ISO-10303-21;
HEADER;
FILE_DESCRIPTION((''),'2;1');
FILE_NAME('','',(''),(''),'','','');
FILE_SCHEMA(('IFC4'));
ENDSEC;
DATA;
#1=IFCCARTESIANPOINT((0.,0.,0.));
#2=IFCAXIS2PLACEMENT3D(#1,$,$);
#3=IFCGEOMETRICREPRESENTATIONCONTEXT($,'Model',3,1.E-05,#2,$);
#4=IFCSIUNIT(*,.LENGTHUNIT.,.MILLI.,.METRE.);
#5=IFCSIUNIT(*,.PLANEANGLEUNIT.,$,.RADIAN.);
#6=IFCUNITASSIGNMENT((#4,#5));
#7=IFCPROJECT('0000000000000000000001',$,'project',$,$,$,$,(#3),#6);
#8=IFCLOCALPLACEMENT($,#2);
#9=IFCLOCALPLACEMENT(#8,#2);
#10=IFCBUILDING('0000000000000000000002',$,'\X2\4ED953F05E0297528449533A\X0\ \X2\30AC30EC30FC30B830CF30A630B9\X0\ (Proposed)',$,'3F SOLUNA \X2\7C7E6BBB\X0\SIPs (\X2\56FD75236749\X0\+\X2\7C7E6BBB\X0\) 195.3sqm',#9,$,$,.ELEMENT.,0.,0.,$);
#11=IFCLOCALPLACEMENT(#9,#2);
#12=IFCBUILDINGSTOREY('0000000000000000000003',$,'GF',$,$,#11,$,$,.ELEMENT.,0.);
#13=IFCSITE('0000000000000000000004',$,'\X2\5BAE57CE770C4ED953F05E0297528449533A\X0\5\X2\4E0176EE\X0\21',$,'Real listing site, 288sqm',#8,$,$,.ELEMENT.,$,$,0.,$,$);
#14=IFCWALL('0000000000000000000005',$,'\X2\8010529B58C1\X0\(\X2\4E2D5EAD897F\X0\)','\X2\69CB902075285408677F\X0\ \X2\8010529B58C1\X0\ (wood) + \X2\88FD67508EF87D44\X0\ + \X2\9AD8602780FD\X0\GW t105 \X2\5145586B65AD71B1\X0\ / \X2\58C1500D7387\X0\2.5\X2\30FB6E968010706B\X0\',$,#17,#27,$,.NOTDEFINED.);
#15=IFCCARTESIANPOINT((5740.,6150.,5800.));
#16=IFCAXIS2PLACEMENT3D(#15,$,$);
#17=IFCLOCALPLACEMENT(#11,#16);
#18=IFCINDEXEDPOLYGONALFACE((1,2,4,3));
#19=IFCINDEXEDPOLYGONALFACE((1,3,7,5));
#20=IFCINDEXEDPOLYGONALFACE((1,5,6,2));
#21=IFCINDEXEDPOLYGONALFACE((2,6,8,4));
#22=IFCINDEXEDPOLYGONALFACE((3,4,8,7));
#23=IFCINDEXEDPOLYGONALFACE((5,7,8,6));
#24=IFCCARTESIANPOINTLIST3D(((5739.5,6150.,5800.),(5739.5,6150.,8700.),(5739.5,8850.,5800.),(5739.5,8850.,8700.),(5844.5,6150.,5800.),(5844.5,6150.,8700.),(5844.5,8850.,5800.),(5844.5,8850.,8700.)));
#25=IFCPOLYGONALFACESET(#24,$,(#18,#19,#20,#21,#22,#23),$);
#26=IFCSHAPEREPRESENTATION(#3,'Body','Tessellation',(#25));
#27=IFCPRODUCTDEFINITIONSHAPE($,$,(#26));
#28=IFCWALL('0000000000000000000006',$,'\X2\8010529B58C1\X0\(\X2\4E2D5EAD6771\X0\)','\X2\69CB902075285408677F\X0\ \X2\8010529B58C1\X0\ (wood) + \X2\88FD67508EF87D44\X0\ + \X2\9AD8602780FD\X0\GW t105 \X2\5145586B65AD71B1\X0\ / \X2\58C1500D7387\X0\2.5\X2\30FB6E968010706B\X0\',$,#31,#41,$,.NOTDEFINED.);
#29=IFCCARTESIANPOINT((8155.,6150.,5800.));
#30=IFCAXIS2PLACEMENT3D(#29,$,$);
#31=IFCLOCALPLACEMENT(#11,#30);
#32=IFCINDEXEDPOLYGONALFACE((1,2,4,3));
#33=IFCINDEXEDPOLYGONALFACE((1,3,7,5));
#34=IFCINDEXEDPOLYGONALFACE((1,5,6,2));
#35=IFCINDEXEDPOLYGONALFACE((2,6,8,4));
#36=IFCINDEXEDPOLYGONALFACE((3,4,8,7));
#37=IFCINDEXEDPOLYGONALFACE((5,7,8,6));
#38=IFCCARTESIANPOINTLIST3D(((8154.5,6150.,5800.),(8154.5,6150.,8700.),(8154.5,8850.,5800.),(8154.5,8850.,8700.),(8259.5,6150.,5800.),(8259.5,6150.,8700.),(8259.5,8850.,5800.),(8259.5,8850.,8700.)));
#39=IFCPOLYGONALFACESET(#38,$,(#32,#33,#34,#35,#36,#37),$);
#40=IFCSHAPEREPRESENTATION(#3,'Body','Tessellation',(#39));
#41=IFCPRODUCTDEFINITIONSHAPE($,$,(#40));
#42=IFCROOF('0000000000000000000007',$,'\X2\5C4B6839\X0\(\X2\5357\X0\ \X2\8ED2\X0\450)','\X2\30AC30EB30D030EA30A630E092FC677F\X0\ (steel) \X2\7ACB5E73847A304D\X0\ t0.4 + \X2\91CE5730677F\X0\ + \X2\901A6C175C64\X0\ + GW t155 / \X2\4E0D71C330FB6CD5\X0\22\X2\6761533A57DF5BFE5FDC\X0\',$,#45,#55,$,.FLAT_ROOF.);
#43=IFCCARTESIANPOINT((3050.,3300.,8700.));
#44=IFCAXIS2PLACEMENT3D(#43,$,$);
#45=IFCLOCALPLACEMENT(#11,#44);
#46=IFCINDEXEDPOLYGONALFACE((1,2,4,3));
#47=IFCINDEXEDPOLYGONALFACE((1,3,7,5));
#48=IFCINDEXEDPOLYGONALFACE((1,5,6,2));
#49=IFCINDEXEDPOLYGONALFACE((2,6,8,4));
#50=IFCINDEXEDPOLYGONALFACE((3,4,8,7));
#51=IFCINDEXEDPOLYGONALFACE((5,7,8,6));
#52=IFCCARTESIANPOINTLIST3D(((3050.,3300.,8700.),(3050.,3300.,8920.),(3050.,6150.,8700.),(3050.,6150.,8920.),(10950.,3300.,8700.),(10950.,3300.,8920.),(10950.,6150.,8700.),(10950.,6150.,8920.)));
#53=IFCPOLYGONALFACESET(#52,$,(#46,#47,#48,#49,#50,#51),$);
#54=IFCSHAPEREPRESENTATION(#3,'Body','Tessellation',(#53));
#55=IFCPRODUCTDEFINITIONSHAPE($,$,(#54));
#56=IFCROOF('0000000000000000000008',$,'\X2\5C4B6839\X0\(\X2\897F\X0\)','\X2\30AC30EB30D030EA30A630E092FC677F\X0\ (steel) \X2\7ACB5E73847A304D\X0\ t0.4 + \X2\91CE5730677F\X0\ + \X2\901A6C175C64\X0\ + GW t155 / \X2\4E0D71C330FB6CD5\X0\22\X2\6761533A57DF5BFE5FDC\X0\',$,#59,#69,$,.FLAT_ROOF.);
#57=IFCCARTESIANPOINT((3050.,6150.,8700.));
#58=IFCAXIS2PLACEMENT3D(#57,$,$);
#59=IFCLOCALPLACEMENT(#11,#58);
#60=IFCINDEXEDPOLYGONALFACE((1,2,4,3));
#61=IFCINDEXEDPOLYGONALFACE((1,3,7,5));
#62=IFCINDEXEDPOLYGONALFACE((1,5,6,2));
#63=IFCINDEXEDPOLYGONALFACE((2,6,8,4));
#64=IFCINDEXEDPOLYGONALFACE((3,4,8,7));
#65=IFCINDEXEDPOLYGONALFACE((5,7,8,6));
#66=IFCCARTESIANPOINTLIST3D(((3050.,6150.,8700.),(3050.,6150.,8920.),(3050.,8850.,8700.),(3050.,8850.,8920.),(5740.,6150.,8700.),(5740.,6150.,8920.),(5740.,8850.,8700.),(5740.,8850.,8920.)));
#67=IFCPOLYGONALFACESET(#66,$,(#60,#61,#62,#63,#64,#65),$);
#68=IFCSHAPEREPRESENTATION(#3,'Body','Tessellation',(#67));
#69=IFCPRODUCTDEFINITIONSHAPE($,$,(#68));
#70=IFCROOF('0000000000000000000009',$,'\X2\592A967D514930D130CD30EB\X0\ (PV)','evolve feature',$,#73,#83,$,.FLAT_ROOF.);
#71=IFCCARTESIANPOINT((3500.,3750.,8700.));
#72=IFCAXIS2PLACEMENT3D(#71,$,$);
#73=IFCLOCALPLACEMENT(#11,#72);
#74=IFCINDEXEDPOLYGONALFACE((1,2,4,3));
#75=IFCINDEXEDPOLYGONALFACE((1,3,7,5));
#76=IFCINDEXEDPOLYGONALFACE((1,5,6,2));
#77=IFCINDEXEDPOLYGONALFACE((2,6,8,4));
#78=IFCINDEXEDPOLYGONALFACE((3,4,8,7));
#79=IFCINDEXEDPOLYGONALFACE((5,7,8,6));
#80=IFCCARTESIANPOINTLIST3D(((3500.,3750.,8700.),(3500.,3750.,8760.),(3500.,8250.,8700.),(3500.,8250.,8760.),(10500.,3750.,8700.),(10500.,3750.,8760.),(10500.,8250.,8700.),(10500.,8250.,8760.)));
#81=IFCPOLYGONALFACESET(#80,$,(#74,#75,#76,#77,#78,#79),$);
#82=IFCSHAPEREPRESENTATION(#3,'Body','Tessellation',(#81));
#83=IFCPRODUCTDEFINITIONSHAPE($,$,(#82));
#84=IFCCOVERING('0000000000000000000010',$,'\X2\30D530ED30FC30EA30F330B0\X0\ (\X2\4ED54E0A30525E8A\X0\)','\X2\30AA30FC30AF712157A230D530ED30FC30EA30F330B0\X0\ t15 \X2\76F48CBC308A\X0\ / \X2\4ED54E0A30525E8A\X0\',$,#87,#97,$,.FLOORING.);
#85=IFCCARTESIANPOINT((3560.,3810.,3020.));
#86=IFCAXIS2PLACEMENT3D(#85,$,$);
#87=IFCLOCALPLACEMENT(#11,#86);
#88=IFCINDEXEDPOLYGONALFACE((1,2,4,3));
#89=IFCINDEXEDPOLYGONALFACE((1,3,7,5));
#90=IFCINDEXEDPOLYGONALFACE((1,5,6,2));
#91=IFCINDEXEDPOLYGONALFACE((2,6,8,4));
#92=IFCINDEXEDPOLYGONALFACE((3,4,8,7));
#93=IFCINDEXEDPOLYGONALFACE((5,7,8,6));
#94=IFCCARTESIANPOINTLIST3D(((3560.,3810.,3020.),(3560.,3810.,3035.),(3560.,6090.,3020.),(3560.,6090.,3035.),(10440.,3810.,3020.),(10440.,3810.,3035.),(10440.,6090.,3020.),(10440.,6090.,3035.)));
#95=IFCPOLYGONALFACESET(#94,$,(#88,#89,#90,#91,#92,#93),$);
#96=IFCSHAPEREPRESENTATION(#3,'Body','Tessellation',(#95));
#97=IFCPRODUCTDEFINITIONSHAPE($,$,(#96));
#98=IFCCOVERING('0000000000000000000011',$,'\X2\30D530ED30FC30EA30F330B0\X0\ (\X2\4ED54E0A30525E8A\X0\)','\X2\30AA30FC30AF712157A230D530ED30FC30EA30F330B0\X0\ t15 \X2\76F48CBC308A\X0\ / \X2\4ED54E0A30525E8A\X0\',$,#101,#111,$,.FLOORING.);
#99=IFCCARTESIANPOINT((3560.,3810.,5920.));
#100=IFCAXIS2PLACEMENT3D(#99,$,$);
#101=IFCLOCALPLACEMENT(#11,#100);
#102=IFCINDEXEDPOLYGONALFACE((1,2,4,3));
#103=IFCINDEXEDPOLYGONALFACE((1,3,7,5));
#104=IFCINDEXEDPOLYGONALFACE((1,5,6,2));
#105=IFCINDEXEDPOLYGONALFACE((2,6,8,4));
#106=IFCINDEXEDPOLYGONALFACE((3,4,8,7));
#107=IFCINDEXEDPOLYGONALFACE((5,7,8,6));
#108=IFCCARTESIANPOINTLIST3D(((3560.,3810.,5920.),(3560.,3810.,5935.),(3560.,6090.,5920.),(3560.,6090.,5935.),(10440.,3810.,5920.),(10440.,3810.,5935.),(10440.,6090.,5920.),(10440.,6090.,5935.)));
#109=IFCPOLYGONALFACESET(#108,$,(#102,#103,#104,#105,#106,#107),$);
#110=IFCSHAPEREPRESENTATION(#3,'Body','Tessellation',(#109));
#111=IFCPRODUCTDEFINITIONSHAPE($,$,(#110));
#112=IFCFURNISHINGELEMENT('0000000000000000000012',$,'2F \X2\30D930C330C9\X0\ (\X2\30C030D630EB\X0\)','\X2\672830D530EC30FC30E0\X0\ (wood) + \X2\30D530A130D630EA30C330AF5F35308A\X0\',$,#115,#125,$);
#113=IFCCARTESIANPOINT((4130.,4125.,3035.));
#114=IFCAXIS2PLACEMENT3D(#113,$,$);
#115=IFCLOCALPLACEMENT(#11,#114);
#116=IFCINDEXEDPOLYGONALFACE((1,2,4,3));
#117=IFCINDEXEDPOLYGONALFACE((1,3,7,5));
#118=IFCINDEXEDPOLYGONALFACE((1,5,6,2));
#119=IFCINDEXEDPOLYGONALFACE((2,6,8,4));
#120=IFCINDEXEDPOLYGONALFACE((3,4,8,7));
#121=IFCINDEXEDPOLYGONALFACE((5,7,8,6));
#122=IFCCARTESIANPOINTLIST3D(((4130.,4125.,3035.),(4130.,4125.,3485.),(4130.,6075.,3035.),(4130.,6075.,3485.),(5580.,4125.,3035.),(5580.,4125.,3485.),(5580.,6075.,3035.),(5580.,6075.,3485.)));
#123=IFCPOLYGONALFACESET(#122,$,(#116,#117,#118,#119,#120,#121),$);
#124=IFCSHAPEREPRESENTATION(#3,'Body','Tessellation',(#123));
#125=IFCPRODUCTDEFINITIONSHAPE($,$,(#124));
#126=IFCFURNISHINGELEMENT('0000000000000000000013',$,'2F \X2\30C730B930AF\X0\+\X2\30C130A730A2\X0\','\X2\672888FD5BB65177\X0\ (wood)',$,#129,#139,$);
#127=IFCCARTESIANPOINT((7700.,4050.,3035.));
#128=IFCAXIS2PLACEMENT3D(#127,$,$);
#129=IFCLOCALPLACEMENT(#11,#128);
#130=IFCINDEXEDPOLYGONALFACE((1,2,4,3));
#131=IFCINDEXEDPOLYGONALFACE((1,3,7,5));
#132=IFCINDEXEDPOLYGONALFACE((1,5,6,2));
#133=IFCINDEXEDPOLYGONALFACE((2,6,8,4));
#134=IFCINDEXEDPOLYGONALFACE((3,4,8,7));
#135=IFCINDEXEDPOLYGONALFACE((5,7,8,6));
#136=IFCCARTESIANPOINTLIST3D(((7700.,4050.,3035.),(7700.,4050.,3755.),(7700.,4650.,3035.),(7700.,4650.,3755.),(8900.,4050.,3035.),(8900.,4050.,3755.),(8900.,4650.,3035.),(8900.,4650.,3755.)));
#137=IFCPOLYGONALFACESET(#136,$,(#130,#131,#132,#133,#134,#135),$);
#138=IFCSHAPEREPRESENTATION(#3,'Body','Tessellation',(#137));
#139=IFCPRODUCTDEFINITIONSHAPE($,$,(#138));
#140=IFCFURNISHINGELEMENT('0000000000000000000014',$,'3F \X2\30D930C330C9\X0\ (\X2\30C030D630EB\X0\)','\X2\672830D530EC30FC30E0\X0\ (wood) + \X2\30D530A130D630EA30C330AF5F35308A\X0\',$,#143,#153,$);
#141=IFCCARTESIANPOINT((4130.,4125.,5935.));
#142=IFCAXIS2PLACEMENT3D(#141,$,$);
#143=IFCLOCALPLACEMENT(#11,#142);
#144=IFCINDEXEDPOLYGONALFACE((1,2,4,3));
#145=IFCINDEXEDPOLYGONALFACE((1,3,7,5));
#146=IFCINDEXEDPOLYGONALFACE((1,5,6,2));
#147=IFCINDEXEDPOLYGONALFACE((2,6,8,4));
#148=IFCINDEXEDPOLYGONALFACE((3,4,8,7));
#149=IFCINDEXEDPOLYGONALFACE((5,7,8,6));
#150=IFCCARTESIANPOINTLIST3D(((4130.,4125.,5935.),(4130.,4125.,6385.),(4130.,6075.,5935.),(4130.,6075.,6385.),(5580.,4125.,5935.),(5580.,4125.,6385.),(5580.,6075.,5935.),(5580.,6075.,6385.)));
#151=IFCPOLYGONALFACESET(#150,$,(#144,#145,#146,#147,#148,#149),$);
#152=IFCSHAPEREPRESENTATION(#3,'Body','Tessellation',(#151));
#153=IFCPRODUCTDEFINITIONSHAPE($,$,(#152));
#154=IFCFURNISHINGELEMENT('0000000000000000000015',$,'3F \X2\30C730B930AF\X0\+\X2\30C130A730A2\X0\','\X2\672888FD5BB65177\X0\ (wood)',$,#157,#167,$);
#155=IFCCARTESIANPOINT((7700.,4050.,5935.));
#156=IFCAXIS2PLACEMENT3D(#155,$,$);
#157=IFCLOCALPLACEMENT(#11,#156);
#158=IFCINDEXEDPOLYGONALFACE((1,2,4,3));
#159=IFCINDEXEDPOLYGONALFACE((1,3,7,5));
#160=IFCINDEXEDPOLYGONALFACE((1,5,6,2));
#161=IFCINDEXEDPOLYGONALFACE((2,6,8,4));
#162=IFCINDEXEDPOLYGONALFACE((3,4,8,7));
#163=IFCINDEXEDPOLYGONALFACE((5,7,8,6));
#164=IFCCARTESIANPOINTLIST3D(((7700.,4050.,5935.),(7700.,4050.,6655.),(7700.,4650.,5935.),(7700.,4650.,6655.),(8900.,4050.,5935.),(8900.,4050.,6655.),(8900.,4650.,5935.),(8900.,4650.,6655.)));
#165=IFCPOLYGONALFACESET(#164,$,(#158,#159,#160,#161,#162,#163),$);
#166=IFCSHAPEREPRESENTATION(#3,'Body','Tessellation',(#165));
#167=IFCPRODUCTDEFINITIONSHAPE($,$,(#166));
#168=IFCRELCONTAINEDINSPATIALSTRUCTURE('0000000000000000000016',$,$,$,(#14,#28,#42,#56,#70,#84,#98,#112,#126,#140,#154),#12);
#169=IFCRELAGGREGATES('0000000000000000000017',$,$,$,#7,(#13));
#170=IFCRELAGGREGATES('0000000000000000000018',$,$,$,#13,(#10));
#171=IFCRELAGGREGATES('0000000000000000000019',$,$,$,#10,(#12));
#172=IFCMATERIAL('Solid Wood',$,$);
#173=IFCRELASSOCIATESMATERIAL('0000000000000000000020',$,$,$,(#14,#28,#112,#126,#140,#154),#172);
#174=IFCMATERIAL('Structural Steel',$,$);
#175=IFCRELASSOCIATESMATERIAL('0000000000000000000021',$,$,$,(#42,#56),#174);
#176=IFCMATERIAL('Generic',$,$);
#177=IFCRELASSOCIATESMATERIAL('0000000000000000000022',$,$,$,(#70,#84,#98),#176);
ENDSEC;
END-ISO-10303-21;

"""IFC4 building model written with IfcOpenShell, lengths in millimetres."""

from ifc_helpers import new_model, si_unit, frame, frame_2d, origin, place, context, project, spatial, rectangle, extrude, material, element, save


model = new_model("IFC4")

# Units and contexts
model_context = context("Model", 3, precision=1e-05, world=origin())
ifc_project = project(units=[si_unit("LENGTHUNIT", "METRE", prefix="MILLI"), si_unit("PLANEANGLEUNIT", "RADIAN")], contexts=[model_context])

# Site, building, storey
site_placement = place(None, origin())
site = spatial("IfcSite", under=ifc_project, at=site_placement, Name="宮城県仙台市青葉区5丁目21", ObjectType="Real listing site, 288sqm", CompositionType="ELEMENT", RefElevation=0.0)
building_placement = place(site_placement, origin())
building = spatial("IfcBuilding", under=site, at=building_placement, Name="仙台市青葉区 ガレージハウス (Proposed)", ObjectType="3F SOLUNA 籾殻SIPs (国産杉+籾殻) 195.3sqm", CompositionType="ELEMENT", ElevationOfRefHeight=0.0, ElevationOfTerrain=0.0)
storey_placement = place(building_placement, origin())
storey = spatial("IfcBuildingStorey", under=building, at=storey_placement, Name="GF", CompositionType="ELEMENT", Elevation=0.0)

# Shared definitions
ifc_material_1 = material(Name="Solid Wood")

# Walls
wall_1_placement = place(storey_placement, frame((5740.0, 6150.0, 5800.0)))
element("IfcWall", 1, at=wall_1_placement, inside=storey, material=ifc_material_1, Name="耐力壁(中庭西)", Description="構造用合板 耐力壁 (wood) + 製材軸組 + 高性能GW t105 充填断熱 / 壁倍率2.5・準耐火", PredefinedType="NOTDEFINED", context=model_context, shape_type="SweptSolid", body=[
    extrude(rectangle(XDim=105.0, YDim=2700.0, at=frame_2d((52.0, 1350.0))), frame((5740.0, 6150.0, 5800.0)), (0.0, 0.0, 1.0), 2900.0),
])
wall_2_placement = place(storey_placement, frame((8155.0, 6150.0, 5800.0)))
element("IfcWall", 2, at=wall_2_placement, inside=storey, material=ifc_material_1, Name="耐力壁(中庭東)", Description="構造用合板 耐力壁 (wood) + 製材軸組 + 高性能GW t105 充填断熱 / 壁倍率2.5・準耐火", PredefinedType="NOTDEFINED", context=model_context, shape_type="SweptSolid", body=[
    extrude(rectangle(XDim=105.0, YDim=2700.0, at=frame_2d((52.0, 1350.0))), frame((8155.0, 6150.0, 5800.0)), (0.0, 0.0, 1.0), 2900.0),
])

# Roofs
ifc_material_2 = material(Name="Structural Steel")
roof_1_placement = place(storey_placement, frame((3050.0, 3300.0, 8700.0)))
element("IfcRoof", 3, at=roof_1_placement, inside=storey, material=ifc_material_2, Name="屋根(南 軒450)", Description="ガルバリウム鋼板 (steel) 立平葺き t0.4 + 野地板 + 通気層 + GW t155 / 不燃・法22条区域対応", PredefinedType="FLAT_ROOF", context=model_context, shape_type="SweptSolid", body=[
    extrude(rectangle(XDim=7900.0, YDim=2850.0, at=frame_2d((3950.0, 1425.0))), frame((3050.0, 3300.0, 8700.0)), (0.0, 0.0, 1.0), 220.0),
])
roof_2_placement = place(storey_placement, frame((3050.0, 6150.0, 8700.0)))
element("IfcRoof", 4, at=roof_2_placement, inside=storey, material=ifc_material_2, Name="屋根(西)", Description="ガルバリウム鋼板 (steel) 立平葺き t0.4 + 野地板 + 通気層 + GW t155 / 不燃・法22条区域対応", PredefinedType="FLAT_ROOF", context=model_context, shape_type="SweptSolid", body=[
    extrude(rectangle(XDim=2690.0, YDim=2700.0, at=frame_2d((1345.0, 1350.0))), frame((3050.0, 6150.0, 8700.0)), (0.0, 0.0, 1.0), 220.0),
])
ifc_material_3 = material(Name="Generic")
roof_3_placement = place(storey_placement, frame((3500.0, 3750.0, 8700.0)))
element("IfcRoof", 5, at=roof_3_placement, inside=storey, material=ifc_material_3, Name="太陽光パネル (PV)", Description="evolve feature", PredefinedType="FLAT_ROOF", context=model_context, shape_type="SweptSolid", body=[
    extrude(rectangle(XDim=7000.0, YDim=4500.0, at=frame_2d((3500.0, 2250.0))), frame((3500.0, 3750.0, 8700.0)), (0.0, 0.0, 1.0), 60.0),
])

# Coverings
covering_1_placement = place(storey_placement, frame((3560.0, 3810.0, 3020.0)))
element("IfcCovering", 6, at=covering_1_placement, inside=storey, material=ifc_material_3, Name="フローリング (仕上げ床)", Description="オーク無垢フローリング t15 直貼り / 仕上げ床", PredefinedType="FLOORING", context=model_context, shape_type="SweptSolid", body=[
    extrude(rectangle(XDim=6880.0, YDim=2280.0, at=frame_2d((3440.0, 1140.0))), frame((3560.0, 3810.0, 3020.0)), (0.0, 0.0, 1.0), 15.0),
])
covering_2_placement = place(storey_placement, frame((3560.0, 3810.0, 5920.0)))
element("IfcCovering", 7, at=covering_2_placement, inside=storey, material=ifc_material_3, Name="フローリング (仕上げ床)", Description="オーク無垢フローリング t15 直貼り / 仕上げ床", PredefinedType="FLOORING", context=model_context, shape_type="SweptSolid", body=[
    extrude(rectangle(XDim=6880.0, YDim=2280.0, at=frame_2d((3440.0, 1140.0))), frame((3560.0, 3810.0, 5920.0)), (0.0, 0.0, 1.0), 15.0),
])

# Furnishing elements
furnishing_1_placement = place(storey_placement, frame((4130.0, 4125.0, 3035.0)))
element("IfcFurnishingElement", 8, at=furnishing_1_placement, inside=storey, material=ifc_material_1, Name="2F ベッド (ダブル)", Description="木フレーム (wood) + ファブリック張り", context=model_context, shape_type="SweptSolid", body=[
    extrude(rectangle(XDim=1450.0, YDim=1950.0, at=frame_2d((725.0, 975.0))), frame((4130.0, 4125.0, 3035.0)), (0.0, 0.0, 1.0), 450.0),
])
furnishing_2_placement = place(storey_placement, frame((7700.0, 4050.0, 3035.0)))
element("IfcFurnishingElement", 9, at=furnishing_2_placement, inside=storey, material=ifc_material_1, Name="2F デスク+チェア", Description="木製家具 (wood)", context=model_context, shape_type="SweptSolid", body=[
    extrude(rectangle(XDim=1200.0, YDim=600.0, at=frame_2d((600.0, 300.0))), frame((7700.0, 4050.0, 3035.0)), (0.0, 0.0, 1.0), 720.0),
])
furnishing_3_placement = place(storey_placement, frame((4130.0, 4125.0, 5935.0)))
element("IfcFurnishingElement", 10, at=furnishing_3_placement, inside=storey, material=ifc_material_1, Name="3F ベッド (ダブル)", Description="木フレーム (wood) + ファブリック張り", context=model_context, shape_type="SweptSolid", body=[
    extrude(rectangle(XDim=1450.0, YDim=1950.0, at=frame_2d((725.0, 975.0))), frame((4130.0, 4125.0, 5935.0)), (0.0, 0.0, 1.0), 450.0),
])
furnishing_4_placement = place(storey_placement, frame((7700.0, 4050.0, 5935.0)))
element("IfcFurnishingElement", 11, at=furnishing_4_placement, inside=storey, material=ifc_material_1, Name="3F デスク+チェア", Description="木製家具 (wood)", context=model_context, shape_type="SweptSolid", body=[
    extrude(rectangle(XDim=1200.0, YDim=600.0, at=frame_2d((600.0, 300.0))), frame((7700.0, 4050.0, 5935.0)), (0.0, 0.0, 1.0), 720.0),
])

save(model, "model.ifc")
